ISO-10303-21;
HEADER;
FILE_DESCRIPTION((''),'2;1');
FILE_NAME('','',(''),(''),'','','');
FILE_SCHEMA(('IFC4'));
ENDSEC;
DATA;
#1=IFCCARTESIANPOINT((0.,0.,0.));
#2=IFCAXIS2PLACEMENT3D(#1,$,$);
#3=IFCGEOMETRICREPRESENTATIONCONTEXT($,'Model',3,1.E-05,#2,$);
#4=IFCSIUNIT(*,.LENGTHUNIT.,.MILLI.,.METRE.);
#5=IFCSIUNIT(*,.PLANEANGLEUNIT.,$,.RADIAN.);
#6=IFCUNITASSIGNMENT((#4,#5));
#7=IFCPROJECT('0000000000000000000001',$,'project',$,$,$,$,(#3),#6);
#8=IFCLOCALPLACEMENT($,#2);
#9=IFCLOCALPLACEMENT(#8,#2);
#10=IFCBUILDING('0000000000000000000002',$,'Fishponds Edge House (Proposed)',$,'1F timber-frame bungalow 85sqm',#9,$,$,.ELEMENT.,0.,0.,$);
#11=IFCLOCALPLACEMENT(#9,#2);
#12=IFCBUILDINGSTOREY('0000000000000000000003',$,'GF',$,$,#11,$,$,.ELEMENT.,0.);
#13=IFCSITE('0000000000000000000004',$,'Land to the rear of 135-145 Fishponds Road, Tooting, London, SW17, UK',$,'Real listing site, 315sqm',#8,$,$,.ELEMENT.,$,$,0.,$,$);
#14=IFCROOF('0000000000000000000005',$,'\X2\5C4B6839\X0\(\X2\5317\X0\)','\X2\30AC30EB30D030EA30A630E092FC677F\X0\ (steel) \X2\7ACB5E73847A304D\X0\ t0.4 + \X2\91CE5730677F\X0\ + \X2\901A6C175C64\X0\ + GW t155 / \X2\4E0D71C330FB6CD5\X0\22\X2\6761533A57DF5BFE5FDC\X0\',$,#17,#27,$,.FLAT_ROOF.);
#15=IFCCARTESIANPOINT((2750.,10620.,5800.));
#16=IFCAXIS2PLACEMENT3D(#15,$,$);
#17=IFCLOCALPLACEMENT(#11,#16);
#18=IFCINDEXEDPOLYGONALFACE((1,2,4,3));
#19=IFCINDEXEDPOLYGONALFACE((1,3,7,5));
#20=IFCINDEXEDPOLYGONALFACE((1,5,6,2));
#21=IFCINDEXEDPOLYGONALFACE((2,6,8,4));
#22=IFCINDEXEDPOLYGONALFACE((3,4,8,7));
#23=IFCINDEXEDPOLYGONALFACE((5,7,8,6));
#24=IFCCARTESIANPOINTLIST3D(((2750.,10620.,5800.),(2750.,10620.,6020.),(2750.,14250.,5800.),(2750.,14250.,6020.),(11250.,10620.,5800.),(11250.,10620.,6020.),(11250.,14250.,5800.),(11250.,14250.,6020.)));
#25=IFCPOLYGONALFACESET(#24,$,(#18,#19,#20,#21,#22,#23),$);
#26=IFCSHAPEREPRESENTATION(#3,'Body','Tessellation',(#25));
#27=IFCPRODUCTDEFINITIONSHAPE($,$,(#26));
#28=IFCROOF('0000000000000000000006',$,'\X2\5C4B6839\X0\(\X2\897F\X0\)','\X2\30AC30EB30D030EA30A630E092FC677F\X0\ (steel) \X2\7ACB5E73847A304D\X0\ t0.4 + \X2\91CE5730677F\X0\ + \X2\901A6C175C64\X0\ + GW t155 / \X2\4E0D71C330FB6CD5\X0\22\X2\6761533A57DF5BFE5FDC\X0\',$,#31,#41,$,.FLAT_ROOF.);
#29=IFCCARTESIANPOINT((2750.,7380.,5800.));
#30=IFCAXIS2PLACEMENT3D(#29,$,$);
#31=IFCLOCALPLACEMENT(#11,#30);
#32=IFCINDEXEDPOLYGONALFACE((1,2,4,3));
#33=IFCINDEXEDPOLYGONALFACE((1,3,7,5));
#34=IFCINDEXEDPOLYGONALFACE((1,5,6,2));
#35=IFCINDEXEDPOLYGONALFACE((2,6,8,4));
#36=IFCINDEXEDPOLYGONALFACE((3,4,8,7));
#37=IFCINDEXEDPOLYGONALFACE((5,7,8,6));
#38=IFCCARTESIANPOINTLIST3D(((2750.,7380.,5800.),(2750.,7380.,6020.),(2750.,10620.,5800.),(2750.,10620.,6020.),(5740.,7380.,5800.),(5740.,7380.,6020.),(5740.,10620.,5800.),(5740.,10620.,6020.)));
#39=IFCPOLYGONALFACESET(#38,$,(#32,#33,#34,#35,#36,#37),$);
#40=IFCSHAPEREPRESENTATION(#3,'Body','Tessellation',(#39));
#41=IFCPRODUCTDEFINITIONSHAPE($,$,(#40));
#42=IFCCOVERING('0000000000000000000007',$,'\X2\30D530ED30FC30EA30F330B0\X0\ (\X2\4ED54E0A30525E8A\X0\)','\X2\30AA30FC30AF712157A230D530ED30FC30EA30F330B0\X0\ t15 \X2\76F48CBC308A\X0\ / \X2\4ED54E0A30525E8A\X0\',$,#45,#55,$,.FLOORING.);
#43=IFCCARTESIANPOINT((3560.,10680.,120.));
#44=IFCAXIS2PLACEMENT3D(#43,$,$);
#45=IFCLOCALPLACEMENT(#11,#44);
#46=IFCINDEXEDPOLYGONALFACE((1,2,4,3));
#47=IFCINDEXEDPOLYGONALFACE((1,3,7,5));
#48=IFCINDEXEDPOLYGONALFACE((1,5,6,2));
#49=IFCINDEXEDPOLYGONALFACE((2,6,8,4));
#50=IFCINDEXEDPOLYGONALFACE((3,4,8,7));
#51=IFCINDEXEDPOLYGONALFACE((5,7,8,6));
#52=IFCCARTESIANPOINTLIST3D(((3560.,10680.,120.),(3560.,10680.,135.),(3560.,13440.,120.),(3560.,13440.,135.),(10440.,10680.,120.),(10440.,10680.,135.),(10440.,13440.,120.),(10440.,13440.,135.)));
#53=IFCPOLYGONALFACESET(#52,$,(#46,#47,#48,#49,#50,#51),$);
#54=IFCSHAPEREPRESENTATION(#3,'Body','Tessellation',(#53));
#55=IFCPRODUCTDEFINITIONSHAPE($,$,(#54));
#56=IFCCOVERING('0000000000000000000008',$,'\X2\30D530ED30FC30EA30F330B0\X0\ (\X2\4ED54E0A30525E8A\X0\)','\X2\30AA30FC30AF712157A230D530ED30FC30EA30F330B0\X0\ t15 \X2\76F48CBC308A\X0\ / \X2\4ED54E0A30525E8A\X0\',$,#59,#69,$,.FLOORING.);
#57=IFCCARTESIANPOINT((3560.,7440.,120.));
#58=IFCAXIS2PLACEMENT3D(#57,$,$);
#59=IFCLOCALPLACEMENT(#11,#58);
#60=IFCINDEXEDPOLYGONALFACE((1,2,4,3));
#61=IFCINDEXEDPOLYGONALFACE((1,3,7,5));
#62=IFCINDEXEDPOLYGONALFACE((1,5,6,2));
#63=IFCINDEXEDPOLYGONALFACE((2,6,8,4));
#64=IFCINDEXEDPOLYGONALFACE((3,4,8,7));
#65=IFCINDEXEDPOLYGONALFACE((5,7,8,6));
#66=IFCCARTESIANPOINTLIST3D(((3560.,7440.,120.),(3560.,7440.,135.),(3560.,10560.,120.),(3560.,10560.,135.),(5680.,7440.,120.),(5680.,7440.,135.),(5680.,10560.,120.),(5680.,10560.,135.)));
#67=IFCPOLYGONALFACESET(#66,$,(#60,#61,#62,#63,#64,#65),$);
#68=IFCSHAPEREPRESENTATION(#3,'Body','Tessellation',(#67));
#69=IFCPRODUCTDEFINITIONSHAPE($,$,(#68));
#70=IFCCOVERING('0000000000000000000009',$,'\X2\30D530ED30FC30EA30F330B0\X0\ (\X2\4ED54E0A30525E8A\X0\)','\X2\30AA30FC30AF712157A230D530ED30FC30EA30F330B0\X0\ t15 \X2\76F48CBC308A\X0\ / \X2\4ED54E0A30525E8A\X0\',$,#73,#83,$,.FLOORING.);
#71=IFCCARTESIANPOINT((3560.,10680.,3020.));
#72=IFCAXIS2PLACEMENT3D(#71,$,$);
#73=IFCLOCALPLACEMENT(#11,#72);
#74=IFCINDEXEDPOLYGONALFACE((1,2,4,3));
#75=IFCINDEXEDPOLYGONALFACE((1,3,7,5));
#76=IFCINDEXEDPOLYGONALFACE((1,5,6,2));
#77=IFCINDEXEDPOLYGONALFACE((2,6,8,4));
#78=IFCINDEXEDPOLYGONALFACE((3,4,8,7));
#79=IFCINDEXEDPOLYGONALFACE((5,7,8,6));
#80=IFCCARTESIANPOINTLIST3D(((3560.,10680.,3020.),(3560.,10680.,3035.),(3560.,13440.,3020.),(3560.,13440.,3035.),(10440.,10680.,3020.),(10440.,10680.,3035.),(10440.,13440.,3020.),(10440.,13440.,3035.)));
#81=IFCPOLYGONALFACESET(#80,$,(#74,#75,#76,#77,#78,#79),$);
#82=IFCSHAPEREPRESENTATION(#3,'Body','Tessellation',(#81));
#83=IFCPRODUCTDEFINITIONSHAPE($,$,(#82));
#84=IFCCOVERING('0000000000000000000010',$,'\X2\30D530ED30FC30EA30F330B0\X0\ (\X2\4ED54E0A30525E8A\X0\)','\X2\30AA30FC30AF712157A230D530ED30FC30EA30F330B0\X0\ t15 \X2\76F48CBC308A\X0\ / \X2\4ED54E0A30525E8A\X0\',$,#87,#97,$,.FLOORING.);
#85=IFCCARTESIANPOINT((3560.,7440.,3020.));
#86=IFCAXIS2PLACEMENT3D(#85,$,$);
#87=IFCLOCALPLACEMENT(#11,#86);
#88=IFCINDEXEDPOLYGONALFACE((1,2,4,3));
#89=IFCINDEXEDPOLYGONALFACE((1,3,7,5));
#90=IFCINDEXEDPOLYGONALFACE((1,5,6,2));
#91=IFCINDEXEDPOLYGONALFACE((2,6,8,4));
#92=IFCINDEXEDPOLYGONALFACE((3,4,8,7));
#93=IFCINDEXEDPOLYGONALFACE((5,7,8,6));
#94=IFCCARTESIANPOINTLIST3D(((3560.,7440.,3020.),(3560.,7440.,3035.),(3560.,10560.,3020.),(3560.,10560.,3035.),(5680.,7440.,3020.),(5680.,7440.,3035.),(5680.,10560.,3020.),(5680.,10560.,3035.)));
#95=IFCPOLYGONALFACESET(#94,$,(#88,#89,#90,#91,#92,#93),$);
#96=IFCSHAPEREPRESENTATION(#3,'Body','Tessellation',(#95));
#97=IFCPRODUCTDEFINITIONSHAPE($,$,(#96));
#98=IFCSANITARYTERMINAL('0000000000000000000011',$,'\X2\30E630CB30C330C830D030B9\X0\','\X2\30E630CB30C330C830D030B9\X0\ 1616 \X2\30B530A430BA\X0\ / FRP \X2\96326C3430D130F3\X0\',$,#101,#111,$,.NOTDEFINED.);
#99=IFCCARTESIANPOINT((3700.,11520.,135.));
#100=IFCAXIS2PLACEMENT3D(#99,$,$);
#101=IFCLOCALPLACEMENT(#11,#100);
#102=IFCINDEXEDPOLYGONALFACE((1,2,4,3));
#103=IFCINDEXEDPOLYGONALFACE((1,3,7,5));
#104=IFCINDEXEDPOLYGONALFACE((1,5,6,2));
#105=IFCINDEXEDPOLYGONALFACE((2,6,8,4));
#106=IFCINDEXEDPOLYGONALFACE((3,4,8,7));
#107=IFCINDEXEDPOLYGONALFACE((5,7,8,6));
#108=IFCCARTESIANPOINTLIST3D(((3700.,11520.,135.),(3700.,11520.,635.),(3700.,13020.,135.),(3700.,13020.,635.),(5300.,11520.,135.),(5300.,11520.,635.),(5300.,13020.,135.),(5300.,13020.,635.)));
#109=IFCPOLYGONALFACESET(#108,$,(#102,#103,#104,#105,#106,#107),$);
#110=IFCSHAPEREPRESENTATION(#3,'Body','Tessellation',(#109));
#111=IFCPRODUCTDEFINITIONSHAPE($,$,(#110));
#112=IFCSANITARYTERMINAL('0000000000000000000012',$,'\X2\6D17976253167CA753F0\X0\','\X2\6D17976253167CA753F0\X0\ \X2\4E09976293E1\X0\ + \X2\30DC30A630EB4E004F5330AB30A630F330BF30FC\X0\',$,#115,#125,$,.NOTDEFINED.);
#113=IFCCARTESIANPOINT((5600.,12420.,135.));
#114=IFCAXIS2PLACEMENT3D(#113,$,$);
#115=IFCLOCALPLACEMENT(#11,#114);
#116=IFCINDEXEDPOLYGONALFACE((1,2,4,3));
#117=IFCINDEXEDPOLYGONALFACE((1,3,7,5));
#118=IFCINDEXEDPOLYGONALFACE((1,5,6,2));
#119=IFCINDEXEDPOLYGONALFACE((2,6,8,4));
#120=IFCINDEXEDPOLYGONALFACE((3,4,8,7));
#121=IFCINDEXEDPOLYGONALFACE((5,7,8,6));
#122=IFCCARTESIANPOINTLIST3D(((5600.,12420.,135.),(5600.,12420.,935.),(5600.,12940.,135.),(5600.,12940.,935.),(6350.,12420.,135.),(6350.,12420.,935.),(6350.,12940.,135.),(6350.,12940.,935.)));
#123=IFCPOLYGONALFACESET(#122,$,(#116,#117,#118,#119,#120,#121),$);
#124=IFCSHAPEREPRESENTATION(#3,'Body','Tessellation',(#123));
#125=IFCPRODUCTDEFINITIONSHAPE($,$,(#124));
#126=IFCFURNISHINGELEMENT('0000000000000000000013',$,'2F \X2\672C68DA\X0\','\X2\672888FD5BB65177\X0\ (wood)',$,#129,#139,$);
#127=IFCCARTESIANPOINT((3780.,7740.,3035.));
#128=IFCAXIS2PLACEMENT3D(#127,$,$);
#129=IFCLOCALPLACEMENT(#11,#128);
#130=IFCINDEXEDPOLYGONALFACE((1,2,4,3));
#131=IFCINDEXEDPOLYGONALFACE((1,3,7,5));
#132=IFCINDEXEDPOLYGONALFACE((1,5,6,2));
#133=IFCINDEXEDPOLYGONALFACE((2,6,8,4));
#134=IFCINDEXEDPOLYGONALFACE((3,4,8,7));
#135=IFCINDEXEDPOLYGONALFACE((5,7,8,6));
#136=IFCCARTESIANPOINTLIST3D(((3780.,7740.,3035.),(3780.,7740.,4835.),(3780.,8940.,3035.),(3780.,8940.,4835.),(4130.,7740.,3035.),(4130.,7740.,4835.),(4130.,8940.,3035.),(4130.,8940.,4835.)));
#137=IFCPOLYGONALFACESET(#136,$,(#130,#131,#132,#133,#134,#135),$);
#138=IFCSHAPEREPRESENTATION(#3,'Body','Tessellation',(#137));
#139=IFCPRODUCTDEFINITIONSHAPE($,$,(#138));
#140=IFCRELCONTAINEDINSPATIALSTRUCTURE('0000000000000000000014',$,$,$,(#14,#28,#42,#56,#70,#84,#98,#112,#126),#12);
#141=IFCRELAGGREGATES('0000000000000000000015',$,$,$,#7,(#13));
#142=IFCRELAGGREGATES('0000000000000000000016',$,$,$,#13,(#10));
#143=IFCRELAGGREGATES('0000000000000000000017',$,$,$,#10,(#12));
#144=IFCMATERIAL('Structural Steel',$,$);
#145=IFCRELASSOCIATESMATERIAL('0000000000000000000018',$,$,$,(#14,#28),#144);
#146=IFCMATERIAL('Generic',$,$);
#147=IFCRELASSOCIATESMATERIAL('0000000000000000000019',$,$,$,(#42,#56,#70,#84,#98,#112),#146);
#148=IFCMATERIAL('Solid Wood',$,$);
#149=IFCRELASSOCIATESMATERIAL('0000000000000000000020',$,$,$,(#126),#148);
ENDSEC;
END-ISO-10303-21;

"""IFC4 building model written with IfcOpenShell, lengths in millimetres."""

from ifc_helpers import new_model, si_unit, frame, frame_2d, origin, place, context, project, spatial, rectangle, extrude, material, element, save


model = new_model("IFC4")

# Units and contexts
model_context = context("Model", 3, precision=1e-05, world=origin())
ifc_project = project(units=[si_unit("LENGTHUNIT", "METRE", prefix="MILLI"), si_unit("PLANEANGLEUNIT", "RADIAN")], contexts=[model_context])

# Site, building, storey
site_placement = place(None, origin())
site = spatial("IfcSite", under=ifc_project, at=site_placement, Name="Land to the rear of 135-145 Fishponds Road, Tooting, London, SW17, UK", ObjectType="Real listing site, 315sqm", CompositionType="ELEMENT", RefElevation=0.0)
building_placement = place(site_placement, origin())
building = spatial("IfcBuilding", under=site, at=building_placement, Name="Fishponds Edge House (Proposed)", ObjectType="1F timber-frame bungalow 85sqm", CompositionType="ELEMENT", ElevationOfRefHeight=0.0, ElevationOfTerrain=0.0)
storey_placement = place(building_placement, origin())
storey = spatial("IfcBuildingStorey", under=building, at=storey_placement, Name="GF", CompositionType="ELEMENT", Elevation=0.0)

# Shared definitions
ifc_material_1 = material(Name="Solid Wood")

# Roofs
ifc_material_2 = material(Name="Structural Steel")
for number, where, name in (
    (1, (2750.0, 10620.0, 5800.0), "屋根(北)"),
):
    element("IfcRoof", number, at=place(storey_placement, frame(where)), inside=storey, material=ifc_material_2, Name=name, Description="ガルバリウム鋼板 (steel) 立平葺き t0.4 + 野地板 + 通気層 + GW t155 / 不燃・法22条区域対応", PredefinedType="FLAT_ROOF", context=model_context, shape_type="SweptSolid", body=[
        extrude(rectangle(XDim=8500.0, YDim=3630.0, at=frame_2d((4250.0, 1815.0))), frame((2750.0, 10620.0, 5800.0)), (0.0, 0.0, 1.0), 220.0),
    ])
roof_placement = place(storey_placement, frame((2750.0, 7380.0, 5800.0)))
element("IfcRoof", 2, at=roof_placement, inside=storey, material=ifc_material_2, Name="屋根(西)", Description="ガルバリウム鋼板 (steel) 立平葺き t0.4 + 野地板 + 通気層 + GW t155 / 不燃・法22条区域対応", PredefinedType="FLAT_ROOF", context=model_context, shape_type="SweptSolid", body=[
    extrude(rectangle(XDim=2990.0, YDim=3240.0, at=frame_2d((1495.0, 1620.0))), frame((2750.0, 7380.0, 5800.0)), (0.0, 0.0, 1.0), 220.0),
])

# Coverings
ifc_material_3 = material(Name="Generic")
covering_1_placement = place(storey_placement, frame((3560.0, 10680.0, 120.0)))
element("IfcCovering", 3, at=covering_1_placement, inside=storey, material=ifc_material_3, Name="フローリング (仕上げ床)", Description="オーク無垢フローリング t15 直貼り / 仕上げ床", PredefinedType="FLOORING", context=model_context, shape_type="SweptSolid", body=[
    extrude(rectangle(XDim=6880.0, YDim=2760.0, at=frame_2d((3440.0, 1380.0))), frame((3560.0, 10680.0, 120.0)), (0.0, 0.0, 1.0), 15.0),
])
covering_2_placement = place(storey_placement, frame((3560.0, 7440.0, 120.0)))
element("IfcCovering", 4, at=covering_2_placement, inside=storey, material=ifc_material_3, Name="フローリング (仕上げ床)", Description="オーク無垢フローリング t15 直貼り / 仕上げ床", PredefinedType="FLOORING", context=model_context, shape_type="SweptSolid", body=[
    extrude(rectangle(XDim=2120.0, YDim=3120.0, at=frame_2d((1060.0, 1560.0))), frame((3560.0, 7440.0, 120.0)), (0.0, 0.0, 1.0), 15.0),
])
covering_3_placement = place(storey_placement, frame((3560.0, 10680.0, 3020.0)))
element("IfcCovering", 5, at=covering_3_placement, inside=storey, material=ifc_material_3, Name="フローリング (仕上げ床)", Description="オーク無垢フローリング t15 直貼り / 仕上げ床", PredefinedType="FLOORING", context=model_context, shape_type="SweptSolid", body=[
    extrude(rectangle(XDim=6880.0, YDim=2760.0, at=frame_2d((3440.0, 1380.0))), frame((3560.0, 10680.0, 3020.0)), (0.0, 0.0, 1.0), 15.0),
])
covering_4_placement = place(storey_placement, frame((3560.0, 7440.0, 3020.0)))
element("IfcCovering", 6, at=covering_4_placement, inside=storey, material=ifc_material_3, Name="フローリング (仕上げ床)", Description="オーク無垢フローリング t15 直貼り / 仕上げ床", PredefinedType="FLOORING", context=model_context, shape_type="SweptSolid", body=[
    extrude(rectangle(XDim=2120.0, YDim=3120.0, at=frame_2d((1060.0, 1560.0))), frame((3560.0, 7440.0, 3020.0)), (0.0, 0.0, 1.0), 15.0),
])

# Sanitary terminals
sanitary_terminal_1_placement = place(storey_placement, frame((3700.0, 11520.0, 135.0)))
element("IfcSanitaryTerminal", 7, at=sanitary_terminal_1_placement, inside=storey, material=ifc_material_3, Name="ユニットバス", Description="ユニットバス 1616 サイズ / FRP 防水パン", PredefinedType="NOTDEFINED", context=model_context, shape_type="SweptSolid", body=[
    extrude(rectangle(XDim=1600.0, YDim=1500.0, at=frame_2d((800.0, 750.0))), frame((3700.0, 11520.0, 135.0)), (0.0, 0.0, 1.0), 500.0),
])
sanitary_terminal_2_placement = place(storey_placement, frame((5600.0, 12420.0, 135.0)))
element("IfcSanitaryTerminal", 8, at=sanitary_terminal_2_placement, inside=storey, material=ifc_material_3, Name="洗面化粧台", Description="洗面化粧台 三面鏡 + ボウル一体カウンター", PredefinedType="NOTDEFINED", context=model_context, shape_type="SweptSolid", body=[
    extrude(rectangle(XDim=750.0, YDim=520.0, at=frame_2d((375.0, 260.0))), frame((5600.0, 12420.0, 135.0)), (0.0, 0.0, 1.0), 800.0),
])

# Furnishing element
furnishing_placement = place(storey_placement, frame((3780.0, 7740.0, 3035.0)))
element("IfcFurnishingElement", 9, at=furnishing_placement, inside=storey, material=ifc_material_1, Name="2F 本棚", Description="木製家具 (wood)", context=model_context, shape_type="SweptSolid", body=[
    extrude(rectangle(XDim=350.0, YDim=1200.0, at=frame_2d((175.0, 600.0))), frame((3780.0, 7740.0, 3035.0)), (0.0, 0.0, 1.0), 1800.0),
])

save(model, "model.ifc")
